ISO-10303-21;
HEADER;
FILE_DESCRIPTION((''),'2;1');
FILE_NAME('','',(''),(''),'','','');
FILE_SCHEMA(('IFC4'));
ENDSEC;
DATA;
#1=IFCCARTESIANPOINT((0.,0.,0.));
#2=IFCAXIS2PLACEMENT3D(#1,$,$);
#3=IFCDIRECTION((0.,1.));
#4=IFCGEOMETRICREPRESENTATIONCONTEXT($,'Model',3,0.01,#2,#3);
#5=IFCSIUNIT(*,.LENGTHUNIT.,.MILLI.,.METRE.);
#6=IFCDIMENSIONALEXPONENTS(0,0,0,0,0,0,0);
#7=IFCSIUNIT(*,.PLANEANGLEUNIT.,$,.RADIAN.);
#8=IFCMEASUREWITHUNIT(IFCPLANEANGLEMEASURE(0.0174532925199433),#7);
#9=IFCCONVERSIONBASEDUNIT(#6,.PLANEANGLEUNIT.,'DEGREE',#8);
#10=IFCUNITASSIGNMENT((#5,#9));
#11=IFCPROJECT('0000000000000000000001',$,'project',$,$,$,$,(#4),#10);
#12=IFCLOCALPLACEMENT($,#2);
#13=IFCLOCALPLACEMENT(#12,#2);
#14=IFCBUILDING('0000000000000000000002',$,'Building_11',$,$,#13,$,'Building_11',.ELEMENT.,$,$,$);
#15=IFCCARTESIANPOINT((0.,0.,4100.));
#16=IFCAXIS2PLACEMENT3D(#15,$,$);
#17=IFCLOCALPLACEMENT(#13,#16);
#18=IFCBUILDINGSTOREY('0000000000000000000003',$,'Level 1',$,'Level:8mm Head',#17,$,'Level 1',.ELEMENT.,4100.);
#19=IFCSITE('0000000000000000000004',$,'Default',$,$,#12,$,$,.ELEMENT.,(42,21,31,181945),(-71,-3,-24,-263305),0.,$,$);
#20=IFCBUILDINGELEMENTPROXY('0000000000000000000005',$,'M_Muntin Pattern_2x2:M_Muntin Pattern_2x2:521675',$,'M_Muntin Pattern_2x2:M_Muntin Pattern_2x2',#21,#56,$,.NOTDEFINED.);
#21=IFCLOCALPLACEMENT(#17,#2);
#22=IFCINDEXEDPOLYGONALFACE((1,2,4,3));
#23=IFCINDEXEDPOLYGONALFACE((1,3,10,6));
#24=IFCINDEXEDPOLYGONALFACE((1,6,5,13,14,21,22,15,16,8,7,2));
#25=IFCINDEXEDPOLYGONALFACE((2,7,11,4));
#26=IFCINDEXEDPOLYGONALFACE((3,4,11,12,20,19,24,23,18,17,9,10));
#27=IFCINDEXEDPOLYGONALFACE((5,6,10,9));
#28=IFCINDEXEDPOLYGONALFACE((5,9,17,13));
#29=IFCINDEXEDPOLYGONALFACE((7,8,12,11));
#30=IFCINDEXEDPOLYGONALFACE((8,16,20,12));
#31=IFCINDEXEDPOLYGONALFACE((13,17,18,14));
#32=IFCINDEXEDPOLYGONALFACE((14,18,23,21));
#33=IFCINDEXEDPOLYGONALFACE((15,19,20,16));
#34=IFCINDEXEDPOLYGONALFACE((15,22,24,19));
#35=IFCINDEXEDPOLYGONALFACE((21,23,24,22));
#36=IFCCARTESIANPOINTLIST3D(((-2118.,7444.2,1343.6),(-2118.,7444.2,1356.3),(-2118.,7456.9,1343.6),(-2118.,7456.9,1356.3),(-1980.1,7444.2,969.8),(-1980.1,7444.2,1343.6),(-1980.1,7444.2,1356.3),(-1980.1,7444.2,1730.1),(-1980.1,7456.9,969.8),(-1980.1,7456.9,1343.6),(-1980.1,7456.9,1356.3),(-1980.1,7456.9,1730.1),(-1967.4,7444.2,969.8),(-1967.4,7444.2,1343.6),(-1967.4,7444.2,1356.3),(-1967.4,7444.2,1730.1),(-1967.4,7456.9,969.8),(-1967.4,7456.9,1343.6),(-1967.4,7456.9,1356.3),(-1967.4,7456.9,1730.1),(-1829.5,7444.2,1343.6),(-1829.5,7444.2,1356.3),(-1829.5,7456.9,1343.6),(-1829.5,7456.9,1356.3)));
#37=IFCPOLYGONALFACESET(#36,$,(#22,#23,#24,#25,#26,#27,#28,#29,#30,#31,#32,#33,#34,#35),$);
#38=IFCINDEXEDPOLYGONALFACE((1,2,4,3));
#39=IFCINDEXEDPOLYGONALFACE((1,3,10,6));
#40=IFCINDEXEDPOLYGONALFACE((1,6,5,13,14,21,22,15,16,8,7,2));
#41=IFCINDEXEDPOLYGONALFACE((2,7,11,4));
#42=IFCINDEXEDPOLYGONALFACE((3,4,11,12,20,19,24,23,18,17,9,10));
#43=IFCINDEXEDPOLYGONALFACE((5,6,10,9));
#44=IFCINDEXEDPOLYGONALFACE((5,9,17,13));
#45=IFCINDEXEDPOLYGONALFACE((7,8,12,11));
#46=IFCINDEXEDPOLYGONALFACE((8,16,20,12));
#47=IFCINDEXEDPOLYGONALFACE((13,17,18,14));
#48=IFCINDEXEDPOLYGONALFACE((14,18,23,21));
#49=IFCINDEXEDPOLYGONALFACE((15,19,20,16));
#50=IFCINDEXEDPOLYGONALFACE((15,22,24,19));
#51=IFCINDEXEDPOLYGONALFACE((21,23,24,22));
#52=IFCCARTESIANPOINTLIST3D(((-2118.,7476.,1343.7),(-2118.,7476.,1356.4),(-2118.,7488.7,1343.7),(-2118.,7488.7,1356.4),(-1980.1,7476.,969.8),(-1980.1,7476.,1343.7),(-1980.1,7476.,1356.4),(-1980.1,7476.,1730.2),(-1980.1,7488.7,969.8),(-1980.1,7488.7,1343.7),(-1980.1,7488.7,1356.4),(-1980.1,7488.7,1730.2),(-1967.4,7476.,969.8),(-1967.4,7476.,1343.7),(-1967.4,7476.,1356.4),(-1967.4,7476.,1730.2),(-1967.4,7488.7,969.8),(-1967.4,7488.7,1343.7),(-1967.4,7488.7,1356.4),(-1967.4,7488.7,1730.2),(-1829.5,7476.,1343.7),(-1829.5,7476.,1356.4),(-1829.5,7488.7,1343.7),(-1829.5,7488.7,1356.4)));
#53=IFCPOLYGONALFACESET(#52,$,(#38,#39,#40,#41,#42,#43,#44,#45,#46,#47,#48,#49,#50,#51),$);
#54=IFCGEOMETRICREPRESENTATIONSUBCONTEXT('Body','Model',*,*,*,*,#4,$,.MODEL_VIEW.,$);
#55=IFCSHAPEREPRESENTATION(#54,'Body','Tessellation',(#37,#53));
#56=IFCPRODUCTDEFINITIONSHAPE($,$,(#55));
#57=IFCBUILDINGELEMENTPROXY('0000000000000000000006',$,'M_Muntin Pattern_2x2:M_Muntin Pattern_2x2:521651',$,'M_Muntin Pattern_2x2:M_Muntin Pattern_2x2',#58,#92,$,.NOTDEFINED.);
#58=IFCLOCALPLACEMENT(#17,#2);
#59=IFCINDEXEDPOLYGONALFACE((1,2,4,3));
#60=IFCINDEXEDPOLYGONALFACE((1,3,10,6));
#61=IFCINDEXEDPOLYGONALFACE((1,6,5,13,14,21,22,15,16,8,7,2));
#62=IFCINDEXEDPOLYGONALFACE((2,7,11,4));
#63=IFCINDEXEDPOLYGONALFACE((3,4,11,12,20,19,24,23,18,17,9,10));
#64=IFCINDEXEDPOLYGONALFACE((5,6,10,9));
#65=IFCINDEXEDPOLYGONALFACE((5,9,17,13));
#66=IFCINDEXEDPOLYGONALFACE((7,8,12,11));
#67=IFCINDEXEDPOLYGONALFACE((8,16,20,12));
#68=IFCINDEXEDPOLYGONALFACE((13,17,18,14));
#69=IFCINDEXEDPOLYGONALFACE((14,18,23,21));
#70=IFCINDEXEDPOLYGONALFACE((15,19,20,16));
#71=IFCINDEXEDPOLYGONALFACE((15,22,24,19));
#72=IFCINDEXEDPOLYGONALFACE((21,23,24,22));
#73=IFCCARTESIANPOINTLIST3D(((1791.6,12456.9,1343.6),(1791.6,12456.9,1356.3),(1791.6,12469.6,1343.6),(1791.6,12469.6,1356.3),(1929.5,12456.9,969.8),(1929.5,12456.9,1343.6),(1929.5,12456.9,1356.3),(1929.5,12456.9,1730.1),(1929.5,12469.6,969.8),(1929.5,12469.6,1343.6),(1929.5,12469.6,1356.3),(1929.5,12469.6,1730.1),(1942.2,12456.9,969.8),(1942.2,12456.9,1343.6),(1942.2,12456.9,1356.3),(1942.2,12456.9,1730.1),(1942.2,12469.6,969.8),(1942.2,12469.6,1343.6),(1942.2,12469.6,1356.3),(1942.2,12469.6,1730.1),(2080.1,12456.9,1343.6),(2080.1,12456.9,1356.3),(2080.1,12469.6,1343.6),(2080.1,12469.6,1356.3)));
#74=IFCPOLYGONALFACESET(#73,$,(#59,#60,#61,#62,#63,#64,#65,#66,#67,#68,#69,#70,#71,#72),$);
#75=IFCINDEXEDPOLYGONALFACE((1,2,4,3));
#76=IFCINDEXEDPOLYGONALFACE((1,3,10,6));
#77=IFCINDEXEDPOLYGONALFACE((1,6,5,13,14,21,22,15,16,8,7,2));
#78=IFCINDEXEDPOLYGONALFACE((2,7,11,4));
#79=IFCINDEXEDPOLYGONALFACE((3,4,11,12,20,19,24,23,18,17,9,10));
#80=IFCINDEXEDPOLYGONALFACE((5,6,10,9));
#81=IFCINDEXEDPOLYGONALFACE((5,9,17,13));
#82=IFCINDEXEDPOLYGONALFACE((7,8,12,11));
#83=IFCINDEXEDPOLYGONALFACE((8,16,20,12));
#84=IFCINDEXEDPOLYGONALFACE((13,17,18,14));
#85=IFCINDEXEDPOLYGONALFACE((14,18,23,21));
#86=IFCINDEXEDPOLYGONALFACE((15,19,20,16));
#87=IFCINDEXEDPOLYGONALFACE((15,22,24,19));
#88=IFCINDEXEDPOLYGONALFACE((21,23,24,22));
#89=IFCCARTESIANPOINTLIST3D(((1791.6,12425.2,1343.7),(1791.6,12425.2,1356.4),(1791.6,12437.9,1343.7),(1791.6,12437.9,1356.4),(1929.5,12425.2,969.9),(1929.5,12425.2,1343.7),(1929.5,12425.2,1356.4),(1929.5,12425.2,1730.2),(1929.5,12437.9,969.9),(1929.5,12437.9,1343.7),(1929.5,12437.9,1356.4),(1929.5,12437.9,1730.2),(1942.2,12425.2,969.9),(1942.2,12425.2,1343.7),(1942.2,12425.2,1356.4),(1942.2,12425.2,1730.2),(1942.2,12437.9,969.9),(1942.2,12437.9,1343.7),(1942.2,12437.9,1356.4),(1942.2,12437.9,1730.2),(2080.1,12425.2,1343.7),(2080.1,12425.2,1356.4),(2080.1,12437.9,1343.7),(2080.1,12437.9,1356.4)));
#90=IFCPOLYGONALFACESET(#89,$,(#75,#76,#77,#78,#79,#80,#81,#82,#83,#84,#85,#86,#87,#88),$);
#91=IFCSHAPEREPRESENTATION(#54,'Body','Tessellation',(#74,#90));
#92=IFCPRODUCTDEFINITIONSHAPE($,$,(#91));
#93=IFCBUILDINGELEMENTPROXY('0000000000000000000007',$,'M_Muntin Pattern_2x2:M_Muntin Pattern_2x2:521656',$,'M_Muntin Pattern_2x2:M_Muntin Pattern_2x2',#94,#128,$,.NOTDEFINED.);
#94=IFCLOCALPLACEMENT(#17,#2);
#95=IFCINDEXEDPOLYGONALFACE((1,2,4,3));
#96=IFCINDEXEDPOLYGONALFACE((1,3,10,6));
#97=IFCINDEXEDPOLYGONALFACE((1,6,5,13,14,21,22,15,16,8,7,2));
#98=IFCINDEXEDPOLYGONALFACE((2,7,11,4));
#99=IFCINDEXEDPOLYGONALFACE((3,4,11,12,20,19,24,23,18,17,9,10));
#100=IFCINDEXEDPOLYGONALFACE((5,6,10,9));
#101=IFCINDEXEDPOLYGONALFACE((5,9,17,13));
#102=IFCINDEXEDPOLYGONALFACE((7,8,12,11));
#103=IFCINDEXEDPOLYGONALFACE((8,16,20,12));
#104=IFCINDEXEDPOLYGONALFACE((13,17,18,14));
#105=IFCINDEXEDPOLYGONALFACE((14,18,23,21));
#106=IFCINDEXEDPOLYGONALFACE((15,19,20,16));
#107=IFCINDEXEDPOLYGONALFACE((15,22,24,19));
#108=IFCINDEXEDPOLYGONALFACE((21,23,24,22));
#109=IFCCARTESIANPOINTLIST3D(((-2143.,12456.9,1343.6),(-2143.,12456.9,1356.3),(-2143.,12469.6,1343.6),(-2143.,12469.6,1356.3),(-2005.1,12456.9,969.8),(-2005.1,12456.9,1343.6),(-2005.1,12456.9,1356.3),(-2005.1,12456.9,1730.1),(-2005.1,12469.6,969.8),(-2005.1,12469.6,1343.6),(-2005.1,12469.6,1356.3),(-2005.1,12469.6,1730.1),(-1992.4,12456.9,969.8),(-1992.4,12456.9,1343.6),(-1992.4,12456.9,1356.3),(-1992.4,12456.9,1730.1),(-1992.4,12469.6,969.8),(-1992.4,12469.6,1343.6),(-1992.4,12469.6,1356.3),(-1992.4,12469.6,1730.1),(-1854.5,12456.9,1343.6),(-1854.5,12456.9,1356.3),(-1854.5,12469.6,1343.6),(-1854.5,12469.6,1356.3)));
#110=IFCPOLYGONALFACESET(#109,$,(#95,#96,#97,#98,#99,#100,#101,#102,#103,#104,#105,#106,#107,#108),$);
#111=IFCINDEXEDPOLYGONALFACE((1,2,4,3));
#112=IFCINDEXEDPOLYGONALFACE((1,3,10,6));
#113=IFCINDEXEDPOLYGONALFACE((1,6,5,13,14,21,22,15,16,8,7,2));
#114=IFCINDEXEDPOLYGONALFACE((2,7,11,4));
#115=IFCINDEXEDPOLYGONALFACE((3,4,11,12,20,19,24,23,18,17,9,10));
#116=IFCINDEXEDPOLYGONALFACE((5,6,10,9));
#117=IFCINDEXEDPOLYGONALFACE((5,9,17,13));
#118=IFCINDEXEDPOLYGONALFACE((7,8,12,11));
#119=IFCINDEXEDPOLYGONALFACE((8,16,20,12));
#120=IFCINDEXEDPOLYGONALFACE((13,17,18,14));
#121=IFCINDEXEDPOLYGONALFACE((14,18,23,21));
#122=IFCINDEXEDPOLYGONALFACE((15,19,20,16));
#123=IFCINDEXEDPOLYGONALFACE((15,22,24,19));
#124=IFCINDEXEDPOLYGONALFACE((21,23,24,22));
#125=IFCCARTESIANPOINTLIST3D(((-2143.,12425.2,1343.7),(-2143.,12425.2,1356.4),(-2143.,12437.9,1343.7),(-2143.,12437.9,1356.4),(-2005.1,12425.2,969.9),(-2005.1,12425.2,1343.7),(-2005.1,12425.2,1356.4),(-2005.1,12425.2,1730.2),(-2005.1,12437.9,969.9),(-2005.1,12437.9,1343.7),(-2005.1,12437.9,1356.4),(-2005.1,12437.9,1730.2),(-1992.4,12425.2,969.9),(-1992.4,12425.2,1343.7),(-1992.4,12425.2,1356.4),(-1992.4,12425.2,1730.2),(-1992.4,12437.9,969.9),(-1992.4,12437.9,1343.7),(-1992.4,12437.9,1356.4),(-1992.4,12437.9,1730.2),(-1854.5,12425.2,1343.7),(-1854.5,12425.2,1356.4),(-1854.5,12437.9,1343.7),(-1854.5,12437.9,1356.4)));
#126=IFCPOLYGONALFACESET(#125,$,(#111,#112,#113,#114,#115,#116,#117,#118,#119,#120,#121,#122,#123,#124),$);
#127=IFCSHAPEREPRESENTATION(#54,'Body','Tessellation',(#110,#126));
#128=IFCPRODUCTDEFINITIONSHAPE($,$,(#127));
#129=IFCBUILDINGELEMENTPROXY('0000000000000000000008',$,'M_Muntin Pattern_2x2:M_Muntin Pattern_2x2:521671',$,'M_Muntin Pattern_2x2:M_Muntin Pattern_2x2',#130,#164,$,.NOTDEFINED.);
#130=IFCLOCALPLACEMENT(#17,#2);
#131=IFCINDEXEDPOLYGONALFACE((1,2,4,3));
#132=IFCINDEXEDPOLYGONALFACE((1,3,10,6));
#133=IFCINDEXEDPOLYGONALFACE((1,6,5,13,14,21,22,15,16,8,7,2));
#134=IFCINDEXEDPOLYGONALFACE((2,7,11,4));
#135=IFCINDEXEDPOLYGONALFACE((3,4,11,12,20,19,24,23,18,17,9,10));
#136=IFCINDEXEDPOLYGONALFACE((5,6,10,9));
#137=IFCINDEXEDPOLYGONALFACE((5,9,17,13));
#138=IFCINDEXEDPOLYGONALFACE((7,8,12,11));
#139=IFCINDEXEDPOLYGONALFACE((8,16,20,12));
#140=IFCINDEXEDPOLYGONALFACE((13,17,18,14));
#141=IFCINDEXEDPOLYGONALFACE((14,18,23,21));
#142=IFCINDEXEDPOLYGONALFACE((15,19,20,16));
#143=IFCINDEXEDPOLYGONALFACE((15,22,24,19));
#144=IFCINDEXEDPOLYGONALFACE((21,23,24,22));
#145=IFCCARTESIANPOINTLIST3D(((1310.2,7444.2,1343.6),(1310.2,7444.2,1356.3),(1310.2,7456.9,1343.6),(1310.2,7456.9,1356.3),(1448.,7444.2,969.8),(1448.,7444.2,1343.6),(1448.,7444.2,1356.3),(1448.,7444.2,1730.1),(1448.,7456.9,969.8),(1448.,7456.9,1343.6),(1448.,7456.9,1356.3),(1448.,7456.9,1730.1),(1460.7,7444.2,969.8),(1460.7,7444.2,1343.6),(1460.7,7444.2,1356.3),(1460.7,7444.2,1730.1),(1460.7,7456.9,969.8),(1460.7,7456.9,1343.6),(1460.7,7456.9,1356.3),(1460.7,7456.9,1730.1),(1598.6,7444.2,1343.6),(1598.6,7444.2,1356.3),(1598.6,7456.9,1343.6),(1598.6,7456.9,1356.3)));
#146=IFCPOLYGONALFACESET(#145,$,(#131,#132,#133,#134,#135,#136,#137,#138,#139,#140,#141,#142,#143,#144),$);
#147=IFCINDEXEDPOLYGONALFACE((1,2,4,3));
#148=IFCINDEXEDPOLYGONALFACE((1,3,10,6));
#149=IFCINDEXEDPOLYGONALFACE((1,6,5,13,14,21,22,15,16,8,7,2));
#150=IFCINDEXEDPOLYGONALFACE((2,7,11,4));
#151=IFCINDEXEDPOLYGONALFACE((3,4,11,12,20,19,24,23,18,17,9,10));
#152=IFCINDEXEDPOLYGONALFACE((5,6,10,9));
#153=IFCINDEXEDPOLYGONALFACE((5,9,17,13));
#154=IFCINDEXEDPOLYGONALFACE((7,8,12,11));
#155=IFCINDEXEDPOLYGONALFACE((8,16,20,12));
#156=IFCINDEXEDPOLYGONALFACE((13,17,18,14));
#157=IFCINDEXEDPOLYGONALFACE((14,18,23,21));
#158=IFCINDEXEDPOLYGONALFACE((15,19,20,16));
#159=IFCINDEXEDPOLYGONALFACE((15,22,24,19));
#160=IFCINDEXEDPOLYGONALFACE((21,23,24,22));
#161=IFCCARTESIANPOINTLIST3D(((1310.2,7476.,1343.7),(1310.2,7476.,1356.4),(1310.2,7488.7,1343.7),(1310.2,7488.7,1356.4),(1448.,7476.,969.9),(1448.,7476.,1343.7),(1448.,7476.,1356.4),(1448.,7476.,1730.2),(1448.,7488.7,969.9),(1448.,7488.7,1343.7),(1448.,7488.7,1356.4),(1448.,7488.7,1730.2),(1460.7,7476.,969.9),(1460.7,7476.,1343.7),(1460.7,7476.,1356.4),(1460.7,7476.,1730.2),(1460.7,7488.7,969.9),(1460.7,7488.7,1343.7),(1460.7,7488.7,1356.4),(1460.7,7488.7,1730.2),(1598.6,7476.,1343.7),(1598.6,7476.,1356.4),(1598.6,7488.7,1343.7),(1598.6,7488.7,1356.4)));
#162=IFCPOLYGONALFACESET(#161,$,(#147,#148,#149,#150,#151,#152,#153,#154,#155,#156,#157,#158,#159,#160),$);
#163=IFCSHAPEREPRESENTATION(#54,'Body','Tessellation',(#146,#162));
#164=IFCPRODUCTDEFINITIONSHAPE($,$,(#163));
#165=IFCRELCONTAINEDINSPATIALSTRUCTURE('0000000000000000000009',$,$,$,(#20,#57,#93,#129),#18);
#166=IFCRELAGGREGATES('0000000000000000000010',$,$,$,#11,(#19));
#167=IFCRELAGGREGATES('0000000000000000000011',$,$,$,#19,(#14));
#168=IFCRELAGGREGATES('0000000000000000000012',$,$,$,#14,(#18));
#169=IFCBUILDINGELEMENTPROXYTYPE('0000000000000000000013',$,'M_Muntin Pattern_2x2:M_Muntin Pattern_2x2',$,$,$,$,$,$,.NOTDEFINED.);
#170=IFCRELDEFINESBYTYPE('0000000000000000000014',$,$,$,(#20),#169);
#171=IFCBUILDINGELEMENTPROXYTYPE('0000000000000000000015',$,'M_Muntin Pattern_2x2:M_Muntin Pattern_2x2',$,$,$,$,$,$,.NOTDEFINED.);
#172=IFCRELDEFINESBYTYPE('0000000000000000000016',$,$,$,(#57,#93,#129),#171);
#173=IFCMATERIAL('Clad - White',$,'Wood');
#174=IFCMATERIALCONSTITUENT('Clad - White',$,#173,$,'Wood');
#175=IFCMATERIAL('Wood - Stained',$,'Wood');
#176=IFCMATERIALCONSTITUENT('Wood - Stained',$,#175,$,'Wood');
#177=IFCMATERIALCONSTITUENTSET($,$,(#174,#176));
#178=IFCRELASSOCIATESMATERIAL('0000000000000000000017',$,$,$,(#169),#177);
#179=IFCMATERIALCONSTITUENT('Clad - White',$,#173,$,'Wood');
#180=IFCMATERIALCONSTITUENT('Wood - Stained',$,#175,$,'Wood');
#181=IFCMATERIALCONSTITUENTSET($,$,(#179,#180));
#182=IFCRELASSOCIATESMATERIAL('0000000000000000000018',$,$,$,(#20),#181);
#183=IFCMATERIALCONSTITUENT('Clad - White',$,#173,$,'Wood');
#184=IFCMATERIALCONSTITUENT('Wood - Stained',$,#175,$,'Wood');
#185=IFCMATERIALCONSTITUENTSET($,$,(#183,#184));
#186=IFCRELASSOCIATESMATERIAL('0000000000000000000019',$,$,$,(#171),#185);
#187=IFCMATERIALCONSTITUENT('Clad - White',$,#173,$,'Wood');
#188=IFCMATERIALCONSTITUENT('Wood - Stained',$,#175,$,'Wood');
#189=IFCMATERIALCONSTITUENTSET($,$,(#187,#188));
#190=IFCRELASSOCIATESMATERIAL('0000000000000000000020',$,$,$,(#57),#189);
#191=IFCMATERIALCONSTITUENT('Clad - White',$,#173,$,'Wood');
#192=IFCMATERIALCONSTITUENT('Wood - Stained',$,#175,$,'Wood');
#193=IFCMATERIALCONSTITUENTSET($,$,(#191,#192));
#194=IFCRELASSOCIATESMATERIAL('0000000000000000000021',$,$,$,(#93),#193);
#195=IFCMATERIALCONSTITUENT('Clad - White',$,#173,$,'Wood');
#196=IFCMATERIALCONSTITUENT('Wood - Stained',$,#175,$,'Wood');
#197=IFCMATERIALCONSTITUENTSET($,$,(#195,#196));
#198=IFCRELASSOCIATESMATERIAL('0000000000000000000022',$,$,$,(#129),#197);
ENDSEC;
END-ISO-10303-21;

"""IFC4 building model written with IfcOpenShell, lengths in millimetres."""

from ifc_helpers import new_model, entity, si_unit, converted_unit, direction, frame, origin, place, context, subcontext, project, spatial, indexed_curve, outline, extrude, source, transform, mapped, material, constituent, constituent_set, type_object, type_shapes, element, save


model = new_model("IFC4")

# Units and contexts
model_context = context("Model", 3, precision=0.01, world=origin(), true_north=direction((0.0, 1.0)))
body_context = subcontext(model_context, "Body", "Model", "MODEL_VIEW")
ifc_project = project(units=[si_unit("LENGTHUNIT", "METRE", prefix="MILLI"), converted_unit("PLANEANGLEUNIT", "DEGREE", entity("IfcPlaneAngleMeasure", 0.0174532925199433), si_unit("PLANEANGLEUNIT", "RADIAN"), dimensions=[0, 0, 0, 0, 0, 0, 0])], contexts=[model_context])

# Site, building, storey
site_placement = place(None, origin())
site = spatial("IfcSite", under=ifc_project, at=site_placement, Name="Default", CompositionType="ELEMENT", RefLatitude=(42, 21, 31, 181945), RefLongitude=(-71, -3, -24, -263305), RefElevation=0.0)
building_placement = place(site_placement, origin())
building = spatial("IfcBuilding", under=site, at=building_placement, Name="Building_11", LongName="Building_11", CompositionType="ELEMENT")
storey_placement = place(building_placement, frame((0.0, 0.0, 4100.0)))
storey = spatial("IfcBuildingStorey", under=building, at=storey_placement, Name="Level 1", ObjectType="Level:8mm Head", LongName="Level 1", CompositionType="ELEMENT", Elevation=4100.0)

# Building element proxies
ifc_material_1 = material(Name="Clad - White", Category="Wood")
ifc_material_2 = material(Name="Wood - Stained", Category="Wood")
ifc_constituent_1 = constituent(ifc_material_1, Name="Clad - White", Category="Wood")
ifc_constituent_2 = constituent(ifc_material_2, Name="Wood - Stained", Category="Wood")
ifc_constituent_set_1 = constituent_set(constituents=[ifc_constituent_1, ifc_constituent_2])
building_element_proxy_type_1 = type_object("IfcBuildingElementProxyType", Name="M_Muntin Pattern_2x2:M_Muntin Pattern_2x2", PredefinedType="NOTDEFINED", material=ifc_constituent_set_1)
shared_shape_1 = source(origin(), body_context, "Body", "SweptSolid", [
    extrude(outline(indexed_curve([(6.4, -6.4), (380.1, -6.4), (380.1, 6.3), (6.4, 6.3), (6.4, 144.2), (-6.3, 144.2), (-6.3, 6.3), (-380.2, 6.3), (-380.2, -6.4), (-6.3, -6.4), (-6.3, -144.2), (6.4, -144.2), (6.4, -6.4)], self_intersect=False)), frame((0.0, 9.5, 380.1), z_axis=(0.0, 1.0, 0.0), x_axis=(0.0, 0.0, 1.0)), (0.0, 0.0, 1.0), 12.7),
    extrude(outline(indexed_curve([(6.4, -6.4), (380.2, -6.4), (380.2, 6.3), (6.4, 6.3), (6.4, 144.2), (-6.3, 144.2), (-6.3, 6.3), (-380.2, 6.3), (-380.2, -6.4), (-6.3, -6.4), (-6.3, -144.2), (6.4, -144.2), (6.4, -6.4)], self_intersect=False)), frame((0.0, -22.2, 380.2), z_axis=(0.0, 1.0, 0.0), x_axis=(0.0, 0.0, 1.0)), (0.0, 0.0, 1.0), 12.7),
])
type_shapes(building_element_proxy_type_1, [shared_shape_1])
ifc_constituent_3 = constituent(ifc_material_1, Name="Clad - White", Category="Wood")
ifc_constituent_4 = constituent(ifc_material_2, Name="Wood - Stained", Category="Wood")
ifc_constituent_set_2 = constituent_set(constituents=[ifc_constituent_3, ifc_constituent_4])
proxy_1_placement = place(storey_placement, frame((-1973.8, 7466.4, 969.8), z_axis=(0.0, 0.0, 1.0), x_axis=(-1.0, 0.0, 0.0)))
element("IfcBuildingElementProxy", 1, at=proxy_1_placement, inside=storey, type_object=building_element_proxy_type_1, material=ifc_constituent_set_2, Name="M_Muntin Pattern_2x2:M_Muntin Pattern_2x2:521675", ObjectType="M_Muntin Pattern_2x2:M_Muntin Pattern_2x2", PredefinedType="NOTDEFINED", context=body_context, shape_type="MappedRepresentation", body=[
    mapped(shared_shape_1, transform((0.0, 0.0, 0.0), scale=1.0)),
])
ifc_constituent_5 = constituent(ifc_material_1, Name="Clad - White", Category="Wood")
ifc_constituent_6 = constituent(ifc_material_2, Name="Wood - Stained", Category="Wood")
ifc_constituent_set_3 = constituent_set(constituents=[ifc_constituent_5, ifc_constituent_6])
ifc_constituent_7 = constituent(ifc_material_1, Name="Clad - White", Category="Wood")
ifc_constituent_8 = constituent(ifc_material_2, Name="Wood - Stained", Category="Wood")
ifc_constituent_set_4 = constituent_set(constituents=[ifc_constituent_7, ifc_constituent_8])
building_element_proxy_type_2 = type_object("IfcBuildingElementProxyType", Name="M_Muntin Pattern_2x2:M_Muntin Pattern_2x2", PredefinedType="NOTDEFINED", material=ifc_constituent_set_4)
shared_shape_2 = source(origin(), body_context, "Body", "SweptSolid", [
    extrude(outline(indexed_curve([(6.4, -6.4), (380.1, -6.4), (380.1, 6.3), (6.4, 6.3), (6.4, 144.2), (-6.3, 144.2), (-6.3, 6.3), (-380.2, 6.3), (-380.2, -6.4), (-6.3, -6.4), (-6.3, -144.2), (6.4, -144.2), (6.4, -6.4)], self_intersect=False)), frame((0.0, -22.2, 380.1), z_axis=(0.0, 1.0, 0.0), x_axis=(0.0, 0.0, 1.0)), (0.0, 0.0, 1.0), 12.7),
    extrude(outline(indexed_curve([(6.4, -6.4), (380.2, -6.4), (380.2, 6.3), (6.4, 6.3), (6.4, 144.2), (-6.3, 144.2), (-6.3, 6.3), (-380.2, 6.3), (-380.2, -6.4), (-6.3, -6.4), (-6.3, -144.2), (6.4, -144.2), (6.4, -6.4)], self_intersect=False)), frame((0.0, 9.5, 380.2), z_axis=(0.0, 1.0, 0.0), x_axis=(0.0, 0.0, 1.0)), (0.0, 0.0, 1.0), 12.7),
])
type_shapes(building_element_proxy_type_2, [shared_shape_2])
proxy_2_placement = place(storey_placement, frame((1935.8, 12447.4, 969.9), z_axis=(0.0, 0.0, 1.0), x_axis=(-1.0, 0.0, 0.0)))
element("IfcBuildingElementProxy", 2, at=proxy_2_placement, inside=storey, type_object=building_element_proxy_type_2, material=ifc_constituent_set_3, Name="M_Muntin Pattern_2x2:M_Muntin Pattern_2x2:521651", ObjectType="M_Muntin Pattern_2x2:M_Muntin Pattern_2x2", PredefinedType="NOTDEFINED", context=body_context, shape_type="MappedRepresentation", body=[
    mapped(shared_shape_2, transform((0.0, 0.0, 0.0), scale=1.0)),
])
ifc_constituent_9 = constituent(ifc_material_1, Name="Clad - White", Category="Wood")
ifc_constituent_10 = constituent(ifc_material_2, Name="Wood - Stained", Category="Wood")
ifc_constituent_set_5 = constituent_set(constituents=[ifc_constituent_9, ifc_constituent_10])
proxy_3_placement = place(storey_placement, frame((-1998.8, 12447.4, 969.9), z_axis=(0.0, 0.0, 1.0), x_axis=(-1.0, 0.0, 0.0)))
element("IfcBuildingElementProxy", 3, at=proxy_3_placement, inside=storey, type_object=building_element_proxy_type_2, material=ifc_constituent_set_5, Name="M_Muntin Pattern_2x2:M_Muntin Pattern_2x2:521656", ObjectType="M_Muntin Pattern_2x2:M_Muntin Pattern_2x2", PredefinedType="NOTDEFINED", context=body_context, shape_type="MappedRepresentation", body=[
    mapped(shared_shape_2, transform((0.0, 0.0, 0.0), scale=1.0)),
])
ifc_constituent_11 = constituent(ifc_material_1, Name="Clad - White", Category="Wood")
ifc_constituent_12 = constituent(ifc_material_2, Name="Wood - Stained", Category="Wood")
ifc_constituent_set_6 = constituent_set(constituents=[ifc_constituent_11, ifc_constituent_12])
proxy_4_placement = place(storey_placement, frame((1454.4, 7466.4, 969.9)))
element("IfcBuildingElementProxy", 4, at=proxy_4_placement, inside=storey, type_object=building_element_proxy_type_2, material=ifc_constituent_set_6, Name="M_Muntin Pattern_2x2:M_Muntin Pattern_2x2:521671", ObjectType="M_Muntin Pattern_2x2:M_Muntin Pattern_2x2", PredefinedType="NOTDEFINED", context=body_context, shape_type="MappedRepresentation", body=[
    mapped(shared_shape_2, transform((0.0, 0.0, 0.0), scale=1.0)),
])

save(model, "model.ifc")
